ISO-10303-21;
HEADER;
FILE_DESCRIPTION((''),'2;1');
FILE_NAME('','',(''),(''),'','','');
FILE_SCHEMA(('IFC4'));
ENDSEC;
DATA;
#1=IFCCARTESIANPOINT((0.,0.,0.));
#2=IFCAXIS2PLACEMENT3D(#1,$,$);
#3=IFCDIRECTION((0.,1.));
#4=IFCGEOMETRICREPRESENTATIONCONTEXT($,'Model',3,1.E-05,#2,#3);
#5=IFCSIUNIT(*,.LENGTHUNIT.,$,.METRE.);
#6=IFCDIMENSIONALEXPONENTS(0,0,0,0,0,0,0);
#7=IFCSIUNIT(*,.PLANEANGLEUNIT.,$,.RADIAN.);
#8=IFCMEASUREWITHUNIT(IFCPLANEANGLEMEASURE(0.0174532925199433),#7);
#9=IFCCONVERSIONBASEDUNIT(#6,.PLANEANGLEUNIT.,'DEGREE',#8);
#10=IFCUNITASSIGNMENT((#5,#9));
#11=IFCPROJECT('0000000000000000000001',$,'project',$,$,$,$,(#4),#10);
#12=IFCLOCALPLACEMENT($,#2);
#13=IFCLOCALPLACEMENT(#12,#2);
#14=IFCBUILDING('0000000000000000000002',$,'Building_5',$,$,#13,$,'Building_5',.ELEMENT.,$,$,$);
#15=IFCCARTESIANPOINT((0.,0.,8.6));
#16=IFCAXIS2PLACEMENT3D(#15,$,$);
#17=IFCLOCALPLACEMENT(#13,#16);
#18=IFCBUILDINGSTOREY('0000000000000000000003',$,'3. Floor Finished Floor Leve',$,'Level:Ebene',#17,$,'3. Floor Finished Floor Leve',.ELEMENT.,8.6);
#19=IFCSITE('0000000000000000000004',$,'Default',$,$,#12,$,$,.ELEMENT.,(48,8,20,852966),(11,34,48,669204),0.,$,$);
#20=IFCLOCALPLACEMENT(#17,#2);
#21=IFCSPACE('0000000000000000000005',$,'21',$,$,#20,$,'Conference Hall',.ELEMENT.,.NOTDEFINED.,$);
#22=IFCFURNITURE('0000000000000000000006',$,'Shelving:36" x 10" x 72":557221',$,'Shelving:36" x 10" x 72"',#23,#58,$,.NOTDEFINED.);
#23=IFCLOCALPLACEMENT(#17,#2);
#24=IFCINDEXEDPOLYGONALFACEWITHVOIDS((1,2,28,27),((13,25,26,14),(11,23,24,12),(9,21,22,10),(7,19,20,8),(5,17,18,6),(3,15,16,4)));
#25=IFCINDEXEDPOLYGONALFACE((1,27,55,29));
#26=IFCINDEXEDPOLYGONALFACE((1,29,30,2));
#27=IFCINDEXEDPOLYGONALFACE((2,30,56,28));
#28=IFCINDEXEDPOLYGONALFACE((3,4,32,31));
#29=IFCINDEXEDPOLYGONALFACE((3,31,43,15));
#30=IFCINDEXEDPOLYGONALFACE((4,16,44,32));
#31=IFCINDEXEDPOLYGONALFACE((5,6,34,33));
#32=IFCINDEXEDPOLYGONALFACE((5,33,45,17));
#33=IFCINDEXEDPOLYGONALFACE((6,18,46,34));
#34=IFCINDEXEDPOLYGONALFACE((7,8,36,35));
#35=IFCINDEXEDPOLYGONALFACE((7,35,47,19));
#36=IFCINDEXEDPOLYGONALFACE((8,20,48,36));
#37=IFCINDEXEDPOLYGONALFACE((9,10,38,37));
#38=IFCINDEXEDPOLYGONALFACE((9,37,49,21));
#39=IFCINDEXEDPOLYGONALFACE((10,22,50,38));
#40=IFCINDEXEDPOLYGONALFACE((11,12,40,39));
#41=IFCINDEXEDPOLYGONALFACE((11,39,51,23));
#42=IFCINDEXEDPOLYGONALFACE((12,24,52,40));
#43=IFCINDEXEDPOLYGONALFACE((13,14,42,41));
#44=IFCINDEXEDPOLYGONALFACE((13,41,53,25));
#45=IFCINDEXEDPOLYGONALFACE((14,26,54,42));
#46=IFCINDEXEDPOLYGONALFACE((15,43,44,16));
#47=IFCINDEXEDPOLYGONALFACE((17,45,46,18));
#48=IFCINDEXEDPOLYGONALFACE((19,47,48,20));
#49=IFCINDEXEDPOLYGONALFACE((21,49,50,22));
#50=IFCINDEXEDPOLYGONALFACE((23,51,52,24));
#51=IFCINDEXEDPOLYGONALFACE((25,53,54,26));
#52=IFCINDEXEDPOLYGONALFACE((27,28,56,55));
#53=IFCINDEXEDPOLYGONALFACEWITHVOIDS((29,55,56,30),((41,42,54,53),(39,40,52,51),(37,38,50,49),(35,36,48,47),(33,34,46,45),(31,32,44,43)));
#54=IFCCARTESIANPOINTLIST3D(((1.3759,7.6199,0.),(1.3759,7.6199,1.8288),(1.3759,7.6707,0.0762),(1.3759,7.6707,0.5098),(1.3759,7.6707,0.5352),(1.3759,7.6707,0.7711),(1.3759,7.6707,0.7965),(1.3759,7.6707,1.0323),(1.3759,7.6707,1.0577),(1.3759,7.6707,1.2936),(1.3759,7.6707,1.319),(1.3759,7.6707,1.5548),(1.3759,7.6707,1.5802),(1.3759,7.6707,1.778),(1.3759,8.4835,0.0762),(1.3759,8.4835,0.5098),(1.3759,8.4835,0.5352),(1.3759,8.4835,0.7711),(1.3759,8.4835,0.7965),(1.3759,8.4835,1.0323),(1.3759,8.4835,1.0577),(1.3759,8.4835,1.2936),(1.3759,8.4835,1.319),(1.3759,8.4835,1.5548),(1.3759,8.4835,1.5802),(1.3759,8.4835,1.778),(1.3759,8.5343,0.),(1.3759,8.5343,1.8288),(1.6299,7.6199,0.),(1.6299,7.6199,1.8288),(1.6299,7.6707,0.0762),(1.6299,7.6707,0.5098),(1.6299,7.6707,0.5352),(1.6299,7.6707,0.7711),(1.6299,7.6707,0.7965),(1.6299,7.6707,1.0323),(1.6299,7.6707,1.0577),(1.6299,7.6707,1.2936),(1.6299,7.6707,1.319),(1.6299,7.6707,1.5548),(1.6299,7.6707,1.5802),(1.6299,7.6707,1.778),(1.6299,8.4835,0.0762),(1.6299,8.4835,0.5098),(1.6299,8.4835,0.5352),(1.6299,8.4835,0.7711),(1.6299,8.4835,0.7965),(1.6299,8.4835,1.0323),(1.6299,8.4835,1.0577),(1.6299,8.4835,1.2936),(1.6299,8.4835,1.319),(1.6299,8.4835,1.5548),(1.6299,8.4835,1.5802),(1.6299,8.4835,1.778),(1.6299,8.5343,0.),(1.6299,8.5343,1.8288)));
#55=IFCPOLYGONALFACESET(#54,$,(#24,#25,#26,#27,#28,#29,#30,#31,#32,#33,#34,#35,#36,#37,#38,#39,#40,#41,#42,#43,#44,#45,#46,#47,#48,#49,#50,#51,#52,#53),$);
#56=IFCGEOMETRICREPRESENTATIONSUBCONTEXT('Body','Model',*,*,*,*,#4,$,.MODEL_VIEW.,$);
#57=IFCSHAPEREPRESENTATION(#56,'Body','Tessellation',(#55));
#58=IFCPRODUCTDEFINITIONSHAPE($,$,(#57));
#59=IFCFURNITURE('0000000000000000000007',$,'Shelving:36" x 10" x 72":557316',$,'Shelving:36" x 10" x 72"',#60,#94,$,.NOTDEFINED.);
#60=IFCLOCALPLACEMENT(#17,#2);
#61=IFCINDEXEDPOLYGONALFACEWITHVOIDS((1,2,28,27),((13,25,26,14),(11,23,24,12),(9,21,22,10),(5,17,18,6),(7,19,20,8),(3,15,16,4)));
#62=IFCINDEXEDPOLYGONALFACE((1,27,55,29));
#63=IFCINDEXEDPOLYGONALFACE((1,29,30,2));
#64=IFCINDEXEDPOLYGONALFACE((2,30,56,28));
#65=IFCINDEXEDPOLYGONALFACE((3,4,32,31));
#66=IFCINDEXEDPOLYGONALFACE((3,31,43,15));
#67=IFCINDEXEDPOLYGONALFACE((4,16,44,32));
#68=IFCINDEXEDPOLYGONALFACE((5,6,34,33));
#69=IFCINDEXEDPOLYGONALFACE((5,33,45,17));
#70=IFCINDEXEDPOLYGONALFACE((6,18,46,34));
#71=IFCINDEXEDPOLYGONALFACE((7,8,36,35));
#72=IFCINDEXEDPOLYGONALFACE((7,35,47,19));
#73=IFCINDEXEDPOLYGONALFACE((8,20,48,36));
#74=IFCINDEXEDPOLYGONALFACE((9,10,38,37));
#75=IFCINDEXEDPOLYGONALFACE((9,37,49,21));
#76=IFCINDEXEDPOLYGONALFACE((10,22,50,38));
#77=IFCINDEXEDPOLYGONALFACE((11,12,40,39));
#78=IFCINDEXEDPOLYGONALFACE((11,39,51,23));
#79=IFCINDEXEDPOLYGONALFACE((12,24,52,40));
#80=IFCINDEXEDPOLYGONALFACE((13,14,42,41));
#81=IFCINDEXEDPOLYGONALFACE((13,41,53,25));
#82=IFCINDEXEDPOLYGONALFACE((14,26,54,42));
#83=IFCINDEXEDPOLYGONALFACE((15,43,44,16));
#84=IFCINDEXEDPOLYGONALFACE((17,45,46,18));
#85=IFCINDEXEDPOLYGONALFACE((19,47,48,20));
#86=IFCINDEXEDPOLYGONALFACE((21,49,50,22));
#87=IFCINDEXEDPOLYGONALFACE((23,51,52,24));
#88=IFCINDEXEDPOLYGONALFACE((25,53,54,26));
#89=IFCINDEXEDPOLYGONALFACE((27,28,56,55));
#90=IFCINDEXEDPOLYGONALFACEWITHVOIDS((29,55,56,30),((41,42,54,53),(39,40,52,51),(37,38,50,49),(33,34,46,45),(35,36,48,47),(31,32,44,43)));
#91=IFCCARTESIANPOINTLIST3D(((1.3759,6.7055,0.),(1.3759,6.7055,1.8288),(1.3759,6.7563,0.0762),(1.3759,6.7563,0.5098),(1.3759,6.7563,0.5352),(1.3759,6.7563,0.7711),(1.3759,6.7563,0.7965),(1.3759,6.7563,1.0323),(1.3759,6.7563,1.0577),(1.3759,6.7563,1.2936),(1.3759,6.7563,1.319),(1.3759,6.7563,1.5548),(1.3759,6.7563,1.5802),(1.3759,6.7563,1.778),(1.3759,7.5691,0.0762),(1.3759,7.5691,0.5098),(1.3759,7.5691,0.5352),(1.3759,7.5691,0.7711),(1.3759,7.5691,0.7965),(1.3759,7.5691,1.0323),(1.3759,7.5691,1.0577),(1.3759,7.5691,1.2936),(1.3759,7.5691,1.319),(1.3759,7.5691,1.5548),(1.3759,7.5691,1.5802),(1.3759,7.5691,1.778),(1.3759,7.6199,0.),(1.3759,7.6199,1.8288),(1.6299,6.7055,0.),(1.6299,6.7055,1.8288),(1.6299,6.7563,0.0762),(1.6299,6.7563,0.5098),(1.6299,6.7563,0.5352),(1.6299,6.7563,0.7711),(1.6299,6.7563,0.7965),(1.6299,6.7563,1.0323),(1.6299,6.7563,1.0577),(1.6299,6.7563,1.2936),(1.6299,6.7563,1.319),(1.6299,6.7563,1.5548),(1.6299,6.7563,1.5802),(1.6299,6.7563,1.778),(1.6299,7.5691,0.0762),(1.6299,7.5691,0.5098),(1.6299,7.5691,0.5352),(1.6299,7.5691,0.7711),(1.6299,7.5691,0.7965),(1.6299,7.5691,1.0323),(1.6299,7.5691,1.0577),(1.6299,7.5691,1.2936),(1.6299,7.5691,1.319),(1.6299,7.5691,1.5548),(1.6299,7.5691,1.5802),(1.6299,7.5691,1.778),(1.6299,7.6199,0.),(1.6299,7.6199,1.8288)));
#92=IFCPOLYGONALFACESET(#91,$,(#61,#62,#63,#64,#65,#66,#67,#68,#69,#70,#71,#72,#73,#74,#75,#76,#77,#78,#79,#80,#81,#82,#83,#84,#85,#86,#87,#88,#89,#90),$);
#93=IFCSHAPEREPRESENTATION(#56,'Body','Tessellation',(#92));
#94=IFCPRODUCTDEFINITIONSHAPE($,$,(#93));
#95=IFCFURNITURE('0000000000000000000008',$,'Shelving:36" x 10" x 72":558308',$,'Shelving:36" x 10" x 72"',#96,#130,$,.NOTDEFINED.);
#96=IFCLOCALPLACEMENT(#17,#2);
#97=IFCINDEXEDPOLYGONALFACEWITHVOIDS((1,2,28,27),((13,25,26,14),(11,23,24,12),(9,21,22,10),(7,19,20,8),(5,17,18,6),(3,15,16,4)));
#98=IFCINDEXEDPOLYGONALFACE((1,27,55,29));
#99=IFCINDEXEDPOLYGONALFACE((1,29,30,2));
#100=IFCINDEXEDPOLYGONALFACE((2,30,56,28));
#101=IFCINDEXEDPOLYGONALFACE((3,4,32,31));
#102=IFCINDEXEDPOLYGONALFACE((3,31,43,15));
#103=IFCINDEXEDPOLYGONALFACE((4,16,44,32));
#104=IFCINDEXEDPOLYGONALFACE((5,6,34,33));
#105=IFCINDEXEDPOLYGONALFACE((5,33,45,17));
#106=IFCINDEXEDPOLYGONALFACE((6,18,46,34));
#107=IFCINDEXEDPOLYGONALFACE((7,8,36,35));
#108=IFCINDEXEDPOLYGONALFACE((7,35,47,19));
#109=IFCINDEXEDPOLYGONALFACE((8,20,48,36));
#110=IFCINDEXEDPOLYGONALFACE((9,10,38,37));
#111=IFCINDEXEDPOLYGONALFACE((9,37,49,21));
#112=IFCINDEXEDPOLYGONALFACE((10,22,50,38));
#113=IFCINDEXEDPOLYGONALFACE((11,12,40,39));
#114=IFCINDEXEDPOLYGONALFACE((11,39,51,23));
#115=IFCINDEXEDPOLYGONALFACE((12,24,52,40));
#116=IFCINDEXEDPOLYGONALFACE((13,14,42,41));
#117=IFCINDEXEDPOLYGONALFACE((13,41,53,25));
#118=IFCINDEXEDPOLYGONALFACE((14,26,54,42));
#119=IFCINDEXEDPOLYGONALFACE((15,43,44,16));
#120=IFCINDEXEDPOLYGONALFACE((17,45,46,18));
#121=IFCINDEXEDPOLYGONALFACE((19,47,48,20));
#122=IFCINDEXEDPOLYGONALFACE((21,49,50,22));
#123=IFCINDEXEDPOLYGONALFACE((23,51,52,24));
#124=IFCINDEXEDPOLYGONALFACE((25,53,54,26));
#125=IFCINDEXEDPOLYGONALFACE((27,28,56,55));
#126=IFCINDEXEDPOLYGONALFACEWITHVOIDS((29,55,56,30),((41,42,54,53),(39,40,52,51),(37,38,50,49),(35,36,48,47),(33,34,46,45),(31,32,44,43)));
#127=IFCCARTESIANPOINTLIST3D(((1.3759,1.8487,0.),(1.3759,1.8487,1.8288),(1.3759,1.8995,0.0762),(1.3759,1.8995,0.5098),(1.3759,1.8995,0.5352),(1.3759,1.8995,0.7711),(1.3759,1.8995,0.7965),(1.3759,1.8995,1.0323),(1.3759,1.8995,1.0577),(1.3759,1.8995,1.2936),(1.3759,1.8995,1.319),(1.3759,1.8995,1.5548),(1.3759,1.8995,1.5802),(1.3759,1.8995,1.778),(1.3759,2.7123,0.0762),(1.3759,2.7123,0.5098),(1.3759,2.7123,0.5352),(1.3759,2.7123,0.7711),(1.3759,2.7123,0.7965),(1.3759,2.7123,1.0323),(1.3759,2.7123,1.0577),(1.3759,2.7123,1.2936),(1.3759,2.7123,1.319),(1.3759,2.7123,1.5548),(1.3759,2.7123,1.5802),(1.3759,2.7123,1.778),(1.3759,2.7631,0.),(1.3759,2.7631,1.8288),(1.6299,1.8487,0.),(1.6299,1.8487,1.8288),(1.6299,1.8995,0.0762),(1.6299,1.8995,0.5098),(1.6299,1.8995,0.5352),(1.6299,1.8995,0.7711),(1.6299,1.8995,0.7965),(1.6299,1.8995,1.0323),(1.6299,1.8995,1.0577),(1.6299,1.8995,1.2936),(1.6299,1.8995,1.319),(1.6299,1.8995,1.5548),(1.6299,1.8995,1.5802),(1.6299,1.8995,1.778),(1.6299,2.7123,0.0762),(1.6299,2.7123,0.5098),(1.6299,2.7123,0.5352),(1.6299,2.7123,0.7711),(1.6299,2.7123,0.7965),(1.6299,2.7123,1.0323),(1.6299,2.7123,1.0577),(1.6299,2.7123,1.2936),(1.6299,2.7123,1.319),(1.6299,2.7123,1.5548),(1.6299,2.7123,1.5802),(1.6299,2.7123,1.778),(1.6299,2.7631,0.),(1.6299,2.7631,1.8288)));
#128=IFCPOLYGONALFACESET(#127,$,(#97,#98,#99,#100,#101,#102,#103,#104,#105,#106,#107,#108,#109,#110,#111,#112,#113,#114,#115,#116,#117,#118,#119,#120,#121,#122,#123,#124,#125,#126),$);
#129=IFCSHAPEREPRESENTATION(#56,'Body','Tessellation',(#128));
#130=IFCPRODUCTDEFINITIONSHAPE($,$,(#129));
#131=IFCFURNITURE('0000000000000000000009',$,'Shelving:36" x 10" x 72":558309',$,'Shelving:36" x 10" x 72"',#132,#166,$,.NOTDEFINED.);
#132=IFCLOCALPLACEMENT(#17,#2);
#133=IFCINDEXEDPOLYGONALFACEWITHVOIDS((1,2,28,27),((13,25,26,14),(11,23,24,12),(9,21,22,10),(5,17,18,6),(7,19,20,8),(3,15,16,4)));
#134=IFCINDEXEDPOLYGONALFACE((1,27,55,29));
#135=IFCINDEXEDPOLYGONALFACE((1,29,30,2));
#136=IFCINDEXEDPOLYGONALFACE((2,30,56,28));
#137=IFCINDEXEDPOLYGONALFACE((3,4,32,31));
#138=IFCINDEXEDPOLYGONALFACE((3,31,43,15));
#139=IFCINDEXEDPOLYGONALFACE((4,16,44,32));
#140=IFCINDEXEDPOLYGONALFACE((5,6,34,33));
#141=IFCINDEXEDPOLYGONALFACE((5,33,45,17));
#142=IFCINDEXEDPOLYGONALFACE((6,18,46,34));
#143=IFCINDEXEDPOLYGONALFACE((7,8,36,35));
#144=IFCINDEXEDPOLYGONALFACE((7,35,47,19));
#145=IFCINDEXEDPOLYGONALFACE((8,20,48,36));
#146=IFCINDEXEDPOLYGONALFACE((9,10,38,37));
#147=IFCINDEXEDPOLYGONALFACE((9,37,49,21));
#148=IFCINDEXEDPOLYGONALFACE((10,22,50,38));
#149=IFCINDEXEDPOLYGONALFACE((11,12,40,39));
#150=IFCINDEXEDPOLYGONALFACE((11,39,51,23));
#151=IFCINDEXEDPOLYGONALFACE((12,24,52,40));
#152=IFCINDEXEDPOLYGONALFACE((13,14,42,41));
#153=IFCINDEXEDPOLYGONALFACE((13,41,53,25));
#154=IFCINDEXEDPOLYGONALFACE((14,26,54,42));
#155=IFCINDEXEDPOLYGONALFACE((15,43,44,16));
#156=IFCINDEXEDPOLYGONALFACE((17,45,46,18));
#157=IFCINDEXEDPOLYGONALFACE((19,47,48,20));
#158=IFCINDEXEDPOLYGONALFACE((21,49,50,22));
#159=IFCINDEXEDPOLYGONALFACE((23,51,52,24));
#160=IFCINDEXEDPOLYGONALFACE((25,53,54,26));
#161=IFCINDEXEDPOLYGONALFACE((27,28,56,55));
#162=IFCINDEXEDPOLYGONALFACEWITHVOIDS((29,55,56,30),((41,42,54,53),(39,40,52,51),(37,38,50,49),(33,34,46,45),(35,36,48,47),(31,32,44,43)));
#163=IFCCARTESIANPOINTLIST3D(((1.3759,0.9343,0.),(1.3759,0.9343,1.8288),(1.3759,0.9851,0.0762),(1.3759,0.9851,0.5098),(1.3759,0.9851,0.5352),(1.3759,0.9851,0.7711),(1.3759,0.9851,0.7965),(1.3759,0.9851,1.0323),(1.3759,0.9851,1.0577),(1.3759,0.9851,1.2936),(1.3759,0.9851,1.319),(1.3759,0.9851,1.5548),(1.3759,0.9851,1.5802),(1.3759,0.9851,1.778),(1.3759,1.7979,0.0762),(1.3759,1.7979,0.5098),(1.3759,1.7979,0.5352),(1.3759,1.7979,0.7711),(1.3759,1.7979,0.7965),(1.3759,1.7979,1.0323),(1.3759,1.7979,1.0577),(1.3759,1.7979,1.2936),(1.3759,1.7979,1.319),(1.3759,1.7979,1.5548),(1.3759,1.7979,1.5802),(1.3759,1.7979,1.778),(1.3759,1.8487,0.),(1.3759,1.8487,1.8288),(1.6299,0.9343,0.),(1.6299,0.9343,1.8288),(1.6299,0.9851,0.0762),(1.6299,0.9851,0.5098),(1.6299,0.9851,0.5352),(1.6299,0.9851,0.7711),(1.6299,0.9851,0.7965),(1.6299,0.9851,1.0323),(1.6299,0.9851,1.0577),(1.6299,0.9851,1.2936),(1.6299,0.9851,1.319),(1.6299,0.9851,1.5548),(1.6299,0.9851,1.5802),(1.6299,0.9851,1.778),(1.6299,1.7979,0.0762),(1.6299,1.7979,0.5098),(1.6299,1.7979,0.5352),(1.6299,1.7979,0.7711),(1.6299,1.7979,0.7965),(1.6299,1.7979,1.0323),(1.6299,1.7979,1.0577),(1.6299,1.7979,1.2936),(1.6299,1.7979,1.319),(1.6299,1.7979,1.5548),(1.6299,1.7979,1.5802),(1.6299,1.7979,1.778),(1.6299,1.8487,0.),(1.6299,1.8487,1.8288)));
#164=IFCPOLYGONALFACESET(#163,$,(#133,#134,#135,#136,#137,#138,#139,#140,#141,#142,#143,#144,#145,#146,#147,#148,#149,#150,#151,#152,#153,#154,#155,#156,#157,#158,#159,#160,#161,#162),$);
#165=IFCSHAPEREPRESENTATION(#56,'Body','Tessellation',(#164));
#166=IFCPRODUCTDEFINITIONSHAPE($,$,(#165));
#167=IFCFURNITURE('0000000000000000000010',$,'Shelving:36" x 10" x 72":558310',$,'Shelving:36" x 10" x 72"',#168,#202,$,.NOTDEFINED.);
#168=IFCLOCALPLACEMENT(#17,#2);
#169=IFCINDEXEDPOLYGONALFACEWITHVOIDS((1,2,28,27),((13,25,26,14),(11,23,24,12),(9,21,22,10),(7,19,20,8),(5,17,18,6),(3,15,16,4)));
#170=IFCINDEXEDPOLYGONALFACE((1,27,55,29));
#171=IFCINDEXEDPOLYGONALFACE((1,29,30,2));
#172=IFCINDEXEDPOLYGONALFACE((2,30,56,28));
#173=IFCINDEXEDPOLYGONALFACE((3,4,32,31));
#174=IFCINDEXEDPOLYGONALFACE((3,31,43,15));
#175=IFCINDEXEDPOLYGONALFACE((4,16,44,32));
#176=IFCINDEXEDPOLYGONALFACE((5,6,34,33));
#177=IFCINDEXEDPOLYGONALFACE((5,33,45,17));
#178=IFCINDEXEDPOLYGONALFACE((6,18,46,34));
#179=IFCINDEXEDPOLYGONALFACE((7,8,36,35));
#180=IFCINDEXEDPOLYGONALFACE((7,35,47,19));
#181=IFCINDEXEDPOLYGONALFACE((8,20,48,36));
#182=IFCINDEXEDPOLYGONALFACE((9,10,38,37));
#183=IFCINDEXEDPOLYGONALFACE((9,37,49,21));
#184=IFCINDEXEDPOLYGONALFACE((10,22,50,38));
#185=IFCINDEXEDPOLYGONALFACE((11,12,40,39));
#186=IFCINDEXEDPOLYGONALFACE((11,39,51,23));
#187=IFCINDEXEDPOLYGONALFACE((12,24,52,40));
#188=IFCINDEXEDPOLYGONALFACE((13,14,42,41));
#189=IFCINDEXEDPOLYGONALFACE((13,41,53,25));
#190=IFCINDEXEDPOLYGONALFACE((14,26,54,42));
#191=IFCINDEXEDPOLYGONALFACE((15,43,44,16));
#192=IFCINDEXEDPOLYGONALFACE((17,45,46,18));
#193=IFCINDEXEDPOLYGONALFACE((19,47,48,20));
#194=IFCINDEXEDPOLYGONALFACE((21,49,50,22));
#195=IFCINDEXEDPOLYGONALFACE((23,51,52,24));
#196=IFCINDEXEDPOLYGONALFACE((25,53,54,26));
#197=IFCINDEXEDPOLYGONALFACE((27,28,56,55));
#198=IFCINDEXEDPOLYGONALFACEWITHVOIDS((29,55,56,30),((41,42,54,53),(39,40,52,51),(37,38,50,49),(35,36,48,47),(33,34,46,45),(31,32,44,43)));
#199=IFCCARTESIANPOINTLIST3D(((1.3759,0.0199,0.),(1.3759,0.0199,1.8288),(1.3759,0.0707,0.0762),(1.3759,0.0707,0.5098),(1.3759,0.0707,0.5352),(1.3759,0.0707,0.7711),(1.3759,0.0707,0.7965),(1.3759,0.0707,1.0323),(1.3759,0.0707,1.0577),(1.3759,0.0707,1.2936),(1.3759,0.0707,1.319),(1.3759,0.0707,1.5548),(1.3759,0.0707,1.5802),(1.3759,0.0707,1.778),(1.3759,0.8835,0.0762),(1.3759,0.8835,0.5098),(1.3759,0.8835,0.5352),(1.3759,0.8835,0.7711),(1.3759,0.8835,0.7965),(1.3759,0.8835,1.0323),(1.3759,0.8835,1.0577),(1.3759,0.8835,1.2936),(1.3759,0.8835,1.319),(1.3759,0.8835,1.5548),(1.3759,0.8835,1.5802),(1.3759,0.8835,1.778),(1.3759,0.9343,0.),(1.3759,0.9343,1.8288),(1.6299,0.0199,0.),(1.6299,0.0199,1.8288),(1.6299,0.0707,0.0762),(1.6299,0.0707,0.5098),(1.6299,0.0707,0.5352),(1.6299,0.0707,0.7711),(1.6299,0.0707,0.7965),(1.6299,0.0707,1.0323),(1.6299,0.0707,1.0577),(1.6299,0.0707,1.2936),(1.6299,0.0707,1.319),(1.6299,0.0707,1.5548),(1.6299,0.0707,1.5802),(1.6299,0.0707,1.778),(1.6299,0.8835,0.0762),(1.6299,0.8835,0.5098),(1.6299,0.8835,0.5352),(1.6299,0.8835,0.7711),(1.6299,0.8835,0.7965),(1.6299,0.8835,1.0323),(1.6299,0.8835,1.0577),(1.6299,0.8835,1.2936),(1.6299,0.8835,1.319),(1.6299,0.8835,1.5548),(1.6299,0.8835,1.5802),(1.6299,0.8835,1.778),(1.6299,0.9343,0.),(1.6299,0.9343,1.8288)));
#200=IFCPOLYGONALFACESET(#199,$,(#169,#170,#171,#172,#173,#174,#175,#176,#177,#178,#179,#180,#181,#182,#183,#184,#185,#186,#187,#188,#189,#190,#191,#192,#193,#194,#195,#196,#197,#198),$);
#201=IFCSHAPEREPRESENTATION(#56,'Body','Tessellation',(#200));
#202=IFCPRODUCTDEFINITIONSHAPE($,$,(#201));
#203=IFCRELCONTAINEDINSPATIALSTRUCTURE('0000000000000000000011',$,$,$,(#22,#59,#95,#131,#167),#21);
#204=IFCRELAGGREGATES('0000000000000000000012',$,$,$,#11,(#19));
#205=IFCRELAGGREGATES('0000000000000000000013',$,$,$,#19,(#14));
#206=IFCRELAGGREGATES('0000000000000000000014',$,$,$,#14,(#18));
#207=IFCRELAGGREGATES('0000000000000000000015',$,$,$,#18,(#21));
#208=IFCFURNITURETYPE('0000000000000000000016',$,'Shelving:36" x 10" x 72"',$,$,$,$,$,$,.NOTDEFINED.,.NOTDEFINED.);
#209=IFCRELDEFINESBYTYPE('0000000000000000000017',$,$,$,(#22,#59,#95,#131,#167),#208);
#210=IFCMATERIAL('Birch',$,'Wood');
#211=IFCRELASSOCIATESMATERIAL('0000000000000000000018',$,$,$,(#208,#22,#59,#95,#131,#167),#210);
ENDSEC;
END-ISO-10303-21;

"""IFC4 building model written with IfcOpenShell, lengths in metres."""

from ifc_helpers import new_model, entity, si_unit, converted_unit, direction, frame, origin, place, context, subcontext, project, spatial, indexed_curve, outline, extrude, source, transform, mapped, material, type_object, type_shapes, element, save


model = new_model("IFC4")

# Units and contexts
model_context = context("Model", 3, precision=1e-05, world=origin(), true_north=direction((0.0, 1.0)))
body_context = subcontext(model_context, "Body", "Model", "MODEL_VIEW")
ifc_project = project(units=[si_unit("LENGTHUNIT", "METRE"), converted_unit("PLANEANGLEUNIT", "DEGREE", entity("IfcPlaneAngleMeasure", 0.0174532925199433), si_unit("PLANEANGLEUNIT", "RADIAN"), dimensions=[0, 0, 0, 0, 0, 0, 0])], contexts=[model_context])

# Site, building, storey
site_placement = place(None, origin())
site = spatial("IfcSite", under=ifc_project, at=site_placement, Name="Default", CompositionType="ELEMENT", RefLatitude=(48, 8, 20, 852966), RefLongitude=(11, 34, 48, 669204), RefElevation=0.0)
building_placement = place(site_placement, origin())
building = spatial("IfcBuilding", under=site, at=building_placement, Name="Building_5", LongName="Building_5", CompositionType="ELEMENT")
storey_placement = place(building_placement, frame((0.0, 0.0, 8.6)))
storey = spatial("IfcBuildingStorey", under=building, at=storey_placement, Name="3. Floor Finished Floor Leve", ObjectType="Level:Ebene", LongName="3. Floor Finished Floor Leve", CompositionType="ELEMENT", Elevation=8.6)

# Shared definitions
space_placement = place(storey_placement, origin())
space = spatial("IfcSpace", under=storey, at=space_placement, Name="21", LongName="Conference Hall", CompositionType="ELEMENT", PredefinedType="NOTDEFINED")

# Furniture
ifc_material_1 = material(Name="Birch", Category="Wood")
furniture_type_1 = type_object("IfcFurnitureType", Name="Shelving:36\" x 10\" x 72\"", AssemblyPlace="NOTDEFINED", PredefinedType="NOTDEFINED", material=ifc_material_1)
shared_shape_1 = source(origin(), body_context, "Body", "SweptSolid", [
    extrude(outline(indexed_curve([(-0.4572, -0.9144), (0.4572, -0.9144), (0.4572, 0.9144), (-0.4572, 0.9144), (-0.4572, -0.9144)], self_intersect=False), holes=[indexed_curve([(-0.4064, 0.8636), (0.4064, 0.8636), (0.4064, 0.6658), (-0.4064, 0.6658), (-0.4064, 0.8636)], self_intersect=False), indexed_curve([(-0.4064, -0.8382), (-0.4064, -0.4046), (0.4064, -0.4046), (0.4064, -0.8382), (-0.4064, -0.8382)], self_intersect=False), indexed_curve([(0.4064, 0.1433), (-0.4064, 0.1433), (-0.4064, 0.3792), (0.4064, 0.3792), (0.4064, 0.1433)], self_intersect=False), indexed_curve([(-0.4064, 0.6404), (0.4064, 0.6404), (0.4064, 0.4046), (-0.4064, 0.4046), (-0.4064, 0.6404)], self_intersect=False), indexed_curve([(-0.4064, 0.1179), (0.4064, 0.1179), (0.4064, -0.1179), (-0.4064, -0.1179), (-0.4064, 0.1179)], self_intersect=False), indexed_curve([(-0.4064, -0.1433), (0.4064, -0.1433), (0.4064, -0.3792), (-0.4064, -0.3792), (-0.4064, -0.1433)], self_intersect=False)]), frame((0.0, -0.4318, 0.9144), z_axis=(0.0, 1.0, 0.0), x_axis=(-1.0, 0.0, 0.0)), (0.0, 0.0, 1.0), 0.254),
])
type_shapes(furniture_type_1, [shared_shape_1])
for number, where, z_axis, x_axis, name in (
    (1, (1.8077, 8.0771, 0.0), (0.0, 0.0, 1.0), (0.0, -1.0, 0.0), "Shelving:36\" x 10\" x 72\":557221"),
    (2, (1.8077, 7.1627, 0.0), (0.0, 0.0, 1.0), (0.0, -1.0, 0.0), "Shelving:36\" x 10\" x 72\":557316"),
    (3, (1.8077, 2.3059, 0.0), (0.0, 0.0, 1.0), (0.0, -1.0, 0.0), "Shelving:36\" x 10\" x 72\":558308"),
    (4, (1.8077, 1.3915, 0.0), (0.0, 0.0, 1.0), (0.0, -1.0, 0.0), "Shelving:36\" x 10\" x 72\":558309"),
    (5, (1.8077, 0.4771, 0.0), (0.0, 0.0, 1.0), (0.0, -1.0, 0.0), "Shelving:36\" x 10\" x 72\":558310"),
):
    element("IfcFurniture", number, at=place(space_placement, frame(where, z_axis=z_axis, x_axis=x_axis)), inside=space, type_object=furniture_type_1, material=ifc_material_1, Name=name, ObjectType="Shelving:36\" x 10\" x 72\"", PredefinedType="NOTDEFINED", context=body_context, shape_type="MappedRepresentation", body=[
        mapped(shared_shape_1, transform((0.0, 0.0, 0.0), scale=1.0)),
    ])

save(model, "model.ifc")
